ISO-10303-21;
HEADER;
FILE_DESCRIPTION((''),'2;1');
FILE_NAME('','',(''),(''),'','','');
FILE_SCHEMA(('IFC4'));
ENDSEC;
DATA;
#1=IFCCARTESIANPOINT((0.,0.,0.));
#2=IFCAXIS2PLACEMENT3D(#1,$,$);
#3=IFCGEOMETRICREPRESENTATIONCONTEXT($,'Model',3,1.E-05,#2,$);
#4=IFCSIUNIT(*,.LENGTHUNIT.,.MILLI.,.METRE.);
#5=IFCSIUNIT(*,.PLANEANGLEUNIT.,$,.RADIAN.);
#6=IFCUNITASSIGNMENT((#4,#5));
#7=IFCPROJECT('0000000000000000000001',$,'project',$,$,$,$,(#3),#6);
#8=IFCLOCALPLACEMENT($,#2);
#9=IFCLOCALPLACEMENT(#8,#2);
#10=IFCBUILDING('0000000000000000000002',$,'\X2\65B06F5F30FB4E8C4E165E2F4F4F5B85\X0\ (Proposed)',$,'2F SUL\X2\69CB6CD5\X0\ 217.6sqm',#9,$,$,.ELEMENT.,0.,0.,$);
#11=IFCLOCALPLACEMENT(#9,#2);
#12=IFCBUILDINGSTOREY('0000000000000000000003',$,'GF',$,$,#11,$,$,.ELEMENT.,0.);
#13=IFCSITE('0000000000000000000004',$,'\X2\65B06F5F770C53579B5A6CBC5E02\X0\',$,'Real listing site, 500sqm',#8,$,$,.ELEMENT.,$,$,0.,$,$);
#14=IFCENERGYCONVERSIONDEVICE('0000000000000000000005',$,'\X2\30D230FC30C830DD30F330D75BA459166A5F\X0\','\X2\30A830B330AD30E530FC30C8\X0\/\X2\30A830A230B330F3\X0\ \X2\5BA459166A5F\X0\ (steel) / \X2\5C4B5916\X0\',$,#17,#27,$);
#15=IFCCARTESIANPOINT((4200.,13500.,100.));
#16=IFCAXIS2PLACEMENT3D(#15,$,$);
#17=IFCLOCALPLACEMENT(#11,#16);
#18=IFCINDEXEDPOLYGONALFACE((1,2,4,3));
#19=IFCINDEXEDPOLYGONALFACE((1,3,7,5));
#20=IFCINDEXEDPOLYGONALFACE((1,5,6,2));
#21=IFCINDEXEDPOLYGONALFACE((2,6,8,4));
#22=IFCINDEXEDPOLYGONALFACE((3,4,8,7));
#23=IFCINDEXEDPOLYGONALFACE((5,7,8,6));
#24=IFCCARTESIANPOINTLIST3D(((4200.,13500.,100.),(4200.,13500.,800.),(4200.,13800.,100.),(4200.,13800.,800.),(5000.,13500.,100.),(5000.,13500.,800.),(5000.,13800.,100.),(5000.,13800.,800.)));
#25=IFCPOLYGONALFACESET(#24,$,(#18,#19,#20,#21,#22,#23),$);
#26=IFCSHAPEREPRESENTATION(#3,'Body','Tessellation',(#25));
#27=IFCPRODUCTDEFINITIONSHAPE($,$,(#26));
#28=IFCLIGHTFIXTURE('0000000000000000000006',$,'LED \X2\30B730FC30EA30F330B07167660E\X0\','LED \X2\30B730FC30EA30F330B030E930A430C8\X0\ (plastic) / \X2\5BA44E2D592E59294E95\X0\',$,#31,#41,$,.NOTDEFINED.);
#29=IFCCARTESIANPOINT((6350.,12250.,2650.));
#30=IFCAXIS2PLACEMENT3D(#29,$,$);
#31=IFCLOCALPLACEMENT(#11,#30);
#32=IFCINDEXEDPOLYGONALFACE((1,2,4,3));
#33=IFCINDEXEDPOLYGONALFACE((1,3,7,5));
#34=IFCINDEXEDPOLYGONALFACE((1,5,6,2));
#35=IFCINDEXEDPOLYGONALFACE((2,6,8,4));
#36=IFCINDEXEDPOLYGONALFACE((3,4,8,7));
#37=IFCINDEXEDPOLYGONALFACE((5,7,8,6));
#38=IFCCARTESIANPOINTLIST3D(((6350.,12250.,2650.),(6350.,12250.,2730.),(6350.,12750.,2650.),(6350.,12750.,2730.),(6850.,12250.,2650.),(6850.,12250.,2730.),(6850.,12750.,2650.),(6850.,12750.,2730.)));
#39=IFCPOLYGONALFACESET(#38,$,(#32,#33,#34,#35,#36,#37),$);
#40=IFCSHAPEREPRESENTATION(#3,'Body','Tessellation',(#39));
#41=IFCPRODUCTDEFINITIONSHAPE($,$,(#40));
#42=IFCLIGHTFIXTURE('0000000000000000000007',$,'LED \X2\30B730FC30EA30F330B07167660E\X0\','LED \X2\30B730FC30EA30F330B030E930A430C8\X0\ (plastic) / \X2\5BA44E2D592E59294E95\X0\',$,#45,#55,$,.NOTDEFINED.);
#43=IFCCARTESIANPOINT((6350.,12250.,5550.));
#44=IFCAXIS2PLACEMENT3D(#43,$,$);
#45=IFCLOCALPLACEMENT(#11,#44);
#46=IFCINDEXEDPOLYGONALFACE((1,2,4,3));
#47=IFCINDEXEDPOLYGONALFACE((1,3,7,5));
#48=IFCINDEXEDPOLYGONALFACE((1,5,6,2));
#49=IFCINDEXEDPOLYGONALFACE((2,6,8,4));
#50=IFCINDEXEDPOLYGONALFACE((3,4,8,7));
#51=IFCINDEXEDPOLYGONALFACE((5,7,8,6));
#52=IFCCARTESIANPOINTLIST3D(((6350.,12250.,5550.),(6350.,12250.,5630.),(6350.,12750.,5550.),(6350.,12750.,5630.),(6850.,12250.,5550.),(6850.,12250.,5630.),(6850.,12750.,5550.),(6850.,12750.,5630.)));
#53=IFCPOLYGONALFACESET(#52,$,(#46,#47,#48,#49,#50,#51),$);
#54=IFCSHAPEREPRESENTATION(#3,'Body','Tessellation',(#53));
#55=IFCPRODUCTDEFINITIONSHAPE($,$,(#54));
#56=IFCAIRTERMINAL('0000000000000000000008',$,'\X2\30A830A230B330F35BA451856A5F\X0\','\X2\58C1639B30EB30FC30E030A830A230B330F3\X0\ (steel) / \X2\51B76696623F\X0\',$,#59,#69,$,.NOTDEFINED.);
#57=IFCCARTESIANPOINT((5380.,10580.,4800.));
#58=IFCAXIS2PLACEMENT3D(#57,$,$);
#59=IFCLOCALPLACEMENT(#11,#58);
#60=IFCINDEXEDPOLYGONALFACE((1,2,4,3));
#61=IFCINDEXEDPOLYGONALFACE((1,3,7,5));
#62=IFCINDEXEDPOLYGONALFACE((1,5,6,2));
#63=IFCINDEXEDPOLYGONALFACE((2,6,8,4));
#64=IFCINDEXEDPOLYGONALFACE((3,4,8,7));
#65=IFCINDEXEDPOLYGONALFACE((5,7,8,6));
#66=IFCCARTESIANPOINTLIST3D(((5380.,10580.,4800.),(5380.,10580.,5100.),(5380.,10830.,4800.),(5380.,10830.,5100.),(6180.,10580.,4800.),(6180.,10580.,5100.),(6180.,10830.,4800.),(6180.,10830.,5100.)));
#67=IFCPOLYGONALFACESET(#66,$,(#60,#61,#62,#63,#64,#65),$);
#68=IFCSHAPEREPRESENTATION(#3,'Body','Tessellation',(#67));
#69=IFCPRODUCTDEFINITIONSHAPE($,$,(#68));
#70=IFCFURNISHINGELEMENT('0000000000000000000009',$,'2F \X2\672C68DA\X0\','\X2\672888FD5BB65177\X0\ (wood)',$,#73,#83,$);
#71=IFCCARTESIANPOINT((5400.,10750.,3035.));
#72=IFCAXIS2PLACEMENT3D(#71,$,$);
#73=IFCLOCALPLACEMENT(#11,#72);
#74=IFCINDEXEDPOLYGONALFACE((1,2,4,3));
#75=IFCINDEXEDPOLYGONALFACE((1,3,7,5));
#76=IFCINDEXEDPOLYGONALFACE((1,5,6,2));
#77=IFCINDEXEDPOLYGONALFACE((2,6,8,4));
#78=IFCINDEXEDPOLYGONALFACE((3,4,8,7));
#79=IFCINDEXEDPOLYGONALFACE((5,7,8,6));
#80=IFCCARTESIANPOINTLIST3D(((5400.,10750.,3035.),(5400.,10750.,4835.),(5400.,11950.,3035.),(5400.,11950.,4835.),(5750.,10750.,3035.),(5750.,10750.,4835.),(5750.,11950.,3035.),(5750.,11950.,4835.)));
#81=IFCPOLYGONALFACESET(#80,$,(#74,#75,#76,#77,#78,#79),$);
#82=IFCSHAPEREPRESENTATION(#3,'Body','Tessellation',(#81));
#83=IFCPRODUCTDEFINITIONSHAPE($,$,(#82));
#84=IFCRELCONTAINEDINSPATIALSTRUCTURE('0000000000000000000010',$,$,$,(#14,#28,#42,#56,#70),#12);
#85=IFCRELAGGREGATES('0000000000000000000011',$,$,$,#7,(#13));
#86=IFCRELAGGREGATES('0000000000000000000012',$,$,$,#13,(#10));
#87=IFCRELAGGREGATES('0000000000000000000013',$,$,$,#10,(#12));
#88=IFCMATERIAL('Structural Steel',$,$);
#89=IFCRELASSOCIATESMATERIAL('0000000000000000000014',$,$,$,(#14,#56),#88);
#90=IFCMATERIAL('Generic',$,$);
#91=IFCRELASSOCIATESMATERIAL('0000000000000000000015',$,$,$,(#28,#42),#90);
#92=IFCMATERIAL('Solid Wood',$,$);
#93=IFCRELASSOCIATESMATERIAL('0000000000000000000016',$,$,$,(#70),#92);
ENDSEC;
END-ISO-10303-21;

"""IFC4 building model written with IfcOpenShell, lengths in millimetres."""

from ifc_helpers import new_model, si_unit, frame, frame_2d, origin, place, context, project, spatial, rectangle, extrude, material, element, save


model = new_model("IFC4")

# Units and contexts
model_context = context("Model", 3, precision=1e-05, world=origin())
ifc_project = project(units=[si_unit("LENGTHUNIT", "METRE", prefix="MILLI"), si_unit("PLANEANGLEUNIT", "RADIAN")], contexts=[model_context])

# Site, building, storey
site_placement = place(None, origin())
site = spatial("IfcSite", under=ifc_project, at=site_placement, Name="新潟県南魚沼市", ObjectType="Real listing site, 500sqm", CompositionType="ELEMENT", RefElevation=0.0)
building_placement = place(site_placement, origin())
building = spatial("IfcBuilding", under=site, at=building_placement, Name="新潟・二世帯住宅 (Proposed)", ObjectType="2F SUL構法 217.6sqm", CompositionType="ELEMENT", ElevationOfRefHeight=0.0, ElevationOfTerrain=0.0)
storey_placement = place(building_placement, origin())
storey = spatial("IfcBuildingStorey", under=building, at=storey_placement, Name="GF", CompositionType="ELEMENT", Elevation=0.0)

# Shared definitions
ifc_material_1 = material(Name="Solid Wood")

# Shared definitions
ifc_material_2 = material(Name="Structural Steel")

# Shared definitions
ifc_material_3 = material(Name="Generic")

# Energy conversion device
energy_conversion_device_placement = place(storey_placement, frame((4200.0, 13500.0, 100.0)))
element("IfcEnergyConversionDevice", 1, at=energy_conversion_device_placement, inside=storey, material=ifc_material_2, Name="ヒートポンプ室外機", Description="エコキュート/エアコン 室外機 (steel) / 屋外", context=model_context, shape_type="SweptSolid", body=[
    extrude(rectangle(XDim=800.0, YDim=300.0, at=frame_2d((400.0, 150.0))), frame((4200.0, 13500.0, 100.0)), (0.0, 0.0, 1.0), 700.0),
])

# Light fixtures
light_fixture_1_placement = place(storey_placement, frame((6350.0, 12250.0, 2650.0)))
element("IfcLightFixture", 2, at=light_fixture_1_placement, inside=storey, material=ifc_material_3, Name="LED シーリング照明", Description="LED シーリングライト (plastic) / 室中央天井", PredefinedType="NOTDEFINED", context=model_context, shape_type="SweptSolid", body=[
    extrude(rectangle(XDim=500.0, YDim=500.0, at=frame_2d((250.0, 250.0))), frame((6350.0, 12250.0, 2650.0)), (0.0, 0.0, 1.0), 80.0),
])
light_fixture_2_placement = place(storey_placement, frame((6350.0, 12250.0, 5550.0)))
element("IfcLightFixture", 3, at=light_fixture_2_placement, inside=storey, material=ifc_material_3, Name="LED シーリング照明", Description="LED シーリングライト (plastic) / 室中央天井", PredefinedType="NOTDEFINED", context=model_context, shape_type="SweptSolid", body=[
    extrude(rectangle(XDim=500.0, YDim=500.0, at=frame_2d((250.0, 250.0))), frame((6350.0, 12250.0, 5550.0)), (0.0, 0.0, 1.0), 80.0),
])

# Air terminal
air_terminal_placement = place(storey_placement, frame((5380.0, 10580.0, 4800.0)))
element("IfcAirTerminal", 4, at=air_terminal_placement, inside=storey, material=ifc_material_2, Name="エアコン室内機", Description="壁掛ルームエアコン (steel) / 冷暖房", PredefinedType="NOTDEFINED", context=model_context, shape_type="SweptSolid", body=[
    extrude(rectangle(XDim=800.0, YDim=250.0, at=frame_2d((400.0, 125.0))), frame((5380.0, 10580.0, 4800.0)), (0.0, 0.0, 1.0), 300.0),
])

# Furnishing element
furnishing_placement = place(storey_placement, frame((5400.0, 10750.0, 3035.0)))
element("IfcFurnishingElement", 5, at=furnishing_placement, inside=storey, material=ifc_material_1, Name="2F 本棚", Description="木製家具 (wood)", context=model_context, shape_type="SweptSolid", body=[
    extrude(rectangle(XDim=350.0, YDim=1200.0, at=frame_2d((175.0, 600.0))), frame((5400.0, 10750.0, 3035.0)), (0.0, 0.0, 1.0), 1800.0),
])

save(model, "model.ifc")
